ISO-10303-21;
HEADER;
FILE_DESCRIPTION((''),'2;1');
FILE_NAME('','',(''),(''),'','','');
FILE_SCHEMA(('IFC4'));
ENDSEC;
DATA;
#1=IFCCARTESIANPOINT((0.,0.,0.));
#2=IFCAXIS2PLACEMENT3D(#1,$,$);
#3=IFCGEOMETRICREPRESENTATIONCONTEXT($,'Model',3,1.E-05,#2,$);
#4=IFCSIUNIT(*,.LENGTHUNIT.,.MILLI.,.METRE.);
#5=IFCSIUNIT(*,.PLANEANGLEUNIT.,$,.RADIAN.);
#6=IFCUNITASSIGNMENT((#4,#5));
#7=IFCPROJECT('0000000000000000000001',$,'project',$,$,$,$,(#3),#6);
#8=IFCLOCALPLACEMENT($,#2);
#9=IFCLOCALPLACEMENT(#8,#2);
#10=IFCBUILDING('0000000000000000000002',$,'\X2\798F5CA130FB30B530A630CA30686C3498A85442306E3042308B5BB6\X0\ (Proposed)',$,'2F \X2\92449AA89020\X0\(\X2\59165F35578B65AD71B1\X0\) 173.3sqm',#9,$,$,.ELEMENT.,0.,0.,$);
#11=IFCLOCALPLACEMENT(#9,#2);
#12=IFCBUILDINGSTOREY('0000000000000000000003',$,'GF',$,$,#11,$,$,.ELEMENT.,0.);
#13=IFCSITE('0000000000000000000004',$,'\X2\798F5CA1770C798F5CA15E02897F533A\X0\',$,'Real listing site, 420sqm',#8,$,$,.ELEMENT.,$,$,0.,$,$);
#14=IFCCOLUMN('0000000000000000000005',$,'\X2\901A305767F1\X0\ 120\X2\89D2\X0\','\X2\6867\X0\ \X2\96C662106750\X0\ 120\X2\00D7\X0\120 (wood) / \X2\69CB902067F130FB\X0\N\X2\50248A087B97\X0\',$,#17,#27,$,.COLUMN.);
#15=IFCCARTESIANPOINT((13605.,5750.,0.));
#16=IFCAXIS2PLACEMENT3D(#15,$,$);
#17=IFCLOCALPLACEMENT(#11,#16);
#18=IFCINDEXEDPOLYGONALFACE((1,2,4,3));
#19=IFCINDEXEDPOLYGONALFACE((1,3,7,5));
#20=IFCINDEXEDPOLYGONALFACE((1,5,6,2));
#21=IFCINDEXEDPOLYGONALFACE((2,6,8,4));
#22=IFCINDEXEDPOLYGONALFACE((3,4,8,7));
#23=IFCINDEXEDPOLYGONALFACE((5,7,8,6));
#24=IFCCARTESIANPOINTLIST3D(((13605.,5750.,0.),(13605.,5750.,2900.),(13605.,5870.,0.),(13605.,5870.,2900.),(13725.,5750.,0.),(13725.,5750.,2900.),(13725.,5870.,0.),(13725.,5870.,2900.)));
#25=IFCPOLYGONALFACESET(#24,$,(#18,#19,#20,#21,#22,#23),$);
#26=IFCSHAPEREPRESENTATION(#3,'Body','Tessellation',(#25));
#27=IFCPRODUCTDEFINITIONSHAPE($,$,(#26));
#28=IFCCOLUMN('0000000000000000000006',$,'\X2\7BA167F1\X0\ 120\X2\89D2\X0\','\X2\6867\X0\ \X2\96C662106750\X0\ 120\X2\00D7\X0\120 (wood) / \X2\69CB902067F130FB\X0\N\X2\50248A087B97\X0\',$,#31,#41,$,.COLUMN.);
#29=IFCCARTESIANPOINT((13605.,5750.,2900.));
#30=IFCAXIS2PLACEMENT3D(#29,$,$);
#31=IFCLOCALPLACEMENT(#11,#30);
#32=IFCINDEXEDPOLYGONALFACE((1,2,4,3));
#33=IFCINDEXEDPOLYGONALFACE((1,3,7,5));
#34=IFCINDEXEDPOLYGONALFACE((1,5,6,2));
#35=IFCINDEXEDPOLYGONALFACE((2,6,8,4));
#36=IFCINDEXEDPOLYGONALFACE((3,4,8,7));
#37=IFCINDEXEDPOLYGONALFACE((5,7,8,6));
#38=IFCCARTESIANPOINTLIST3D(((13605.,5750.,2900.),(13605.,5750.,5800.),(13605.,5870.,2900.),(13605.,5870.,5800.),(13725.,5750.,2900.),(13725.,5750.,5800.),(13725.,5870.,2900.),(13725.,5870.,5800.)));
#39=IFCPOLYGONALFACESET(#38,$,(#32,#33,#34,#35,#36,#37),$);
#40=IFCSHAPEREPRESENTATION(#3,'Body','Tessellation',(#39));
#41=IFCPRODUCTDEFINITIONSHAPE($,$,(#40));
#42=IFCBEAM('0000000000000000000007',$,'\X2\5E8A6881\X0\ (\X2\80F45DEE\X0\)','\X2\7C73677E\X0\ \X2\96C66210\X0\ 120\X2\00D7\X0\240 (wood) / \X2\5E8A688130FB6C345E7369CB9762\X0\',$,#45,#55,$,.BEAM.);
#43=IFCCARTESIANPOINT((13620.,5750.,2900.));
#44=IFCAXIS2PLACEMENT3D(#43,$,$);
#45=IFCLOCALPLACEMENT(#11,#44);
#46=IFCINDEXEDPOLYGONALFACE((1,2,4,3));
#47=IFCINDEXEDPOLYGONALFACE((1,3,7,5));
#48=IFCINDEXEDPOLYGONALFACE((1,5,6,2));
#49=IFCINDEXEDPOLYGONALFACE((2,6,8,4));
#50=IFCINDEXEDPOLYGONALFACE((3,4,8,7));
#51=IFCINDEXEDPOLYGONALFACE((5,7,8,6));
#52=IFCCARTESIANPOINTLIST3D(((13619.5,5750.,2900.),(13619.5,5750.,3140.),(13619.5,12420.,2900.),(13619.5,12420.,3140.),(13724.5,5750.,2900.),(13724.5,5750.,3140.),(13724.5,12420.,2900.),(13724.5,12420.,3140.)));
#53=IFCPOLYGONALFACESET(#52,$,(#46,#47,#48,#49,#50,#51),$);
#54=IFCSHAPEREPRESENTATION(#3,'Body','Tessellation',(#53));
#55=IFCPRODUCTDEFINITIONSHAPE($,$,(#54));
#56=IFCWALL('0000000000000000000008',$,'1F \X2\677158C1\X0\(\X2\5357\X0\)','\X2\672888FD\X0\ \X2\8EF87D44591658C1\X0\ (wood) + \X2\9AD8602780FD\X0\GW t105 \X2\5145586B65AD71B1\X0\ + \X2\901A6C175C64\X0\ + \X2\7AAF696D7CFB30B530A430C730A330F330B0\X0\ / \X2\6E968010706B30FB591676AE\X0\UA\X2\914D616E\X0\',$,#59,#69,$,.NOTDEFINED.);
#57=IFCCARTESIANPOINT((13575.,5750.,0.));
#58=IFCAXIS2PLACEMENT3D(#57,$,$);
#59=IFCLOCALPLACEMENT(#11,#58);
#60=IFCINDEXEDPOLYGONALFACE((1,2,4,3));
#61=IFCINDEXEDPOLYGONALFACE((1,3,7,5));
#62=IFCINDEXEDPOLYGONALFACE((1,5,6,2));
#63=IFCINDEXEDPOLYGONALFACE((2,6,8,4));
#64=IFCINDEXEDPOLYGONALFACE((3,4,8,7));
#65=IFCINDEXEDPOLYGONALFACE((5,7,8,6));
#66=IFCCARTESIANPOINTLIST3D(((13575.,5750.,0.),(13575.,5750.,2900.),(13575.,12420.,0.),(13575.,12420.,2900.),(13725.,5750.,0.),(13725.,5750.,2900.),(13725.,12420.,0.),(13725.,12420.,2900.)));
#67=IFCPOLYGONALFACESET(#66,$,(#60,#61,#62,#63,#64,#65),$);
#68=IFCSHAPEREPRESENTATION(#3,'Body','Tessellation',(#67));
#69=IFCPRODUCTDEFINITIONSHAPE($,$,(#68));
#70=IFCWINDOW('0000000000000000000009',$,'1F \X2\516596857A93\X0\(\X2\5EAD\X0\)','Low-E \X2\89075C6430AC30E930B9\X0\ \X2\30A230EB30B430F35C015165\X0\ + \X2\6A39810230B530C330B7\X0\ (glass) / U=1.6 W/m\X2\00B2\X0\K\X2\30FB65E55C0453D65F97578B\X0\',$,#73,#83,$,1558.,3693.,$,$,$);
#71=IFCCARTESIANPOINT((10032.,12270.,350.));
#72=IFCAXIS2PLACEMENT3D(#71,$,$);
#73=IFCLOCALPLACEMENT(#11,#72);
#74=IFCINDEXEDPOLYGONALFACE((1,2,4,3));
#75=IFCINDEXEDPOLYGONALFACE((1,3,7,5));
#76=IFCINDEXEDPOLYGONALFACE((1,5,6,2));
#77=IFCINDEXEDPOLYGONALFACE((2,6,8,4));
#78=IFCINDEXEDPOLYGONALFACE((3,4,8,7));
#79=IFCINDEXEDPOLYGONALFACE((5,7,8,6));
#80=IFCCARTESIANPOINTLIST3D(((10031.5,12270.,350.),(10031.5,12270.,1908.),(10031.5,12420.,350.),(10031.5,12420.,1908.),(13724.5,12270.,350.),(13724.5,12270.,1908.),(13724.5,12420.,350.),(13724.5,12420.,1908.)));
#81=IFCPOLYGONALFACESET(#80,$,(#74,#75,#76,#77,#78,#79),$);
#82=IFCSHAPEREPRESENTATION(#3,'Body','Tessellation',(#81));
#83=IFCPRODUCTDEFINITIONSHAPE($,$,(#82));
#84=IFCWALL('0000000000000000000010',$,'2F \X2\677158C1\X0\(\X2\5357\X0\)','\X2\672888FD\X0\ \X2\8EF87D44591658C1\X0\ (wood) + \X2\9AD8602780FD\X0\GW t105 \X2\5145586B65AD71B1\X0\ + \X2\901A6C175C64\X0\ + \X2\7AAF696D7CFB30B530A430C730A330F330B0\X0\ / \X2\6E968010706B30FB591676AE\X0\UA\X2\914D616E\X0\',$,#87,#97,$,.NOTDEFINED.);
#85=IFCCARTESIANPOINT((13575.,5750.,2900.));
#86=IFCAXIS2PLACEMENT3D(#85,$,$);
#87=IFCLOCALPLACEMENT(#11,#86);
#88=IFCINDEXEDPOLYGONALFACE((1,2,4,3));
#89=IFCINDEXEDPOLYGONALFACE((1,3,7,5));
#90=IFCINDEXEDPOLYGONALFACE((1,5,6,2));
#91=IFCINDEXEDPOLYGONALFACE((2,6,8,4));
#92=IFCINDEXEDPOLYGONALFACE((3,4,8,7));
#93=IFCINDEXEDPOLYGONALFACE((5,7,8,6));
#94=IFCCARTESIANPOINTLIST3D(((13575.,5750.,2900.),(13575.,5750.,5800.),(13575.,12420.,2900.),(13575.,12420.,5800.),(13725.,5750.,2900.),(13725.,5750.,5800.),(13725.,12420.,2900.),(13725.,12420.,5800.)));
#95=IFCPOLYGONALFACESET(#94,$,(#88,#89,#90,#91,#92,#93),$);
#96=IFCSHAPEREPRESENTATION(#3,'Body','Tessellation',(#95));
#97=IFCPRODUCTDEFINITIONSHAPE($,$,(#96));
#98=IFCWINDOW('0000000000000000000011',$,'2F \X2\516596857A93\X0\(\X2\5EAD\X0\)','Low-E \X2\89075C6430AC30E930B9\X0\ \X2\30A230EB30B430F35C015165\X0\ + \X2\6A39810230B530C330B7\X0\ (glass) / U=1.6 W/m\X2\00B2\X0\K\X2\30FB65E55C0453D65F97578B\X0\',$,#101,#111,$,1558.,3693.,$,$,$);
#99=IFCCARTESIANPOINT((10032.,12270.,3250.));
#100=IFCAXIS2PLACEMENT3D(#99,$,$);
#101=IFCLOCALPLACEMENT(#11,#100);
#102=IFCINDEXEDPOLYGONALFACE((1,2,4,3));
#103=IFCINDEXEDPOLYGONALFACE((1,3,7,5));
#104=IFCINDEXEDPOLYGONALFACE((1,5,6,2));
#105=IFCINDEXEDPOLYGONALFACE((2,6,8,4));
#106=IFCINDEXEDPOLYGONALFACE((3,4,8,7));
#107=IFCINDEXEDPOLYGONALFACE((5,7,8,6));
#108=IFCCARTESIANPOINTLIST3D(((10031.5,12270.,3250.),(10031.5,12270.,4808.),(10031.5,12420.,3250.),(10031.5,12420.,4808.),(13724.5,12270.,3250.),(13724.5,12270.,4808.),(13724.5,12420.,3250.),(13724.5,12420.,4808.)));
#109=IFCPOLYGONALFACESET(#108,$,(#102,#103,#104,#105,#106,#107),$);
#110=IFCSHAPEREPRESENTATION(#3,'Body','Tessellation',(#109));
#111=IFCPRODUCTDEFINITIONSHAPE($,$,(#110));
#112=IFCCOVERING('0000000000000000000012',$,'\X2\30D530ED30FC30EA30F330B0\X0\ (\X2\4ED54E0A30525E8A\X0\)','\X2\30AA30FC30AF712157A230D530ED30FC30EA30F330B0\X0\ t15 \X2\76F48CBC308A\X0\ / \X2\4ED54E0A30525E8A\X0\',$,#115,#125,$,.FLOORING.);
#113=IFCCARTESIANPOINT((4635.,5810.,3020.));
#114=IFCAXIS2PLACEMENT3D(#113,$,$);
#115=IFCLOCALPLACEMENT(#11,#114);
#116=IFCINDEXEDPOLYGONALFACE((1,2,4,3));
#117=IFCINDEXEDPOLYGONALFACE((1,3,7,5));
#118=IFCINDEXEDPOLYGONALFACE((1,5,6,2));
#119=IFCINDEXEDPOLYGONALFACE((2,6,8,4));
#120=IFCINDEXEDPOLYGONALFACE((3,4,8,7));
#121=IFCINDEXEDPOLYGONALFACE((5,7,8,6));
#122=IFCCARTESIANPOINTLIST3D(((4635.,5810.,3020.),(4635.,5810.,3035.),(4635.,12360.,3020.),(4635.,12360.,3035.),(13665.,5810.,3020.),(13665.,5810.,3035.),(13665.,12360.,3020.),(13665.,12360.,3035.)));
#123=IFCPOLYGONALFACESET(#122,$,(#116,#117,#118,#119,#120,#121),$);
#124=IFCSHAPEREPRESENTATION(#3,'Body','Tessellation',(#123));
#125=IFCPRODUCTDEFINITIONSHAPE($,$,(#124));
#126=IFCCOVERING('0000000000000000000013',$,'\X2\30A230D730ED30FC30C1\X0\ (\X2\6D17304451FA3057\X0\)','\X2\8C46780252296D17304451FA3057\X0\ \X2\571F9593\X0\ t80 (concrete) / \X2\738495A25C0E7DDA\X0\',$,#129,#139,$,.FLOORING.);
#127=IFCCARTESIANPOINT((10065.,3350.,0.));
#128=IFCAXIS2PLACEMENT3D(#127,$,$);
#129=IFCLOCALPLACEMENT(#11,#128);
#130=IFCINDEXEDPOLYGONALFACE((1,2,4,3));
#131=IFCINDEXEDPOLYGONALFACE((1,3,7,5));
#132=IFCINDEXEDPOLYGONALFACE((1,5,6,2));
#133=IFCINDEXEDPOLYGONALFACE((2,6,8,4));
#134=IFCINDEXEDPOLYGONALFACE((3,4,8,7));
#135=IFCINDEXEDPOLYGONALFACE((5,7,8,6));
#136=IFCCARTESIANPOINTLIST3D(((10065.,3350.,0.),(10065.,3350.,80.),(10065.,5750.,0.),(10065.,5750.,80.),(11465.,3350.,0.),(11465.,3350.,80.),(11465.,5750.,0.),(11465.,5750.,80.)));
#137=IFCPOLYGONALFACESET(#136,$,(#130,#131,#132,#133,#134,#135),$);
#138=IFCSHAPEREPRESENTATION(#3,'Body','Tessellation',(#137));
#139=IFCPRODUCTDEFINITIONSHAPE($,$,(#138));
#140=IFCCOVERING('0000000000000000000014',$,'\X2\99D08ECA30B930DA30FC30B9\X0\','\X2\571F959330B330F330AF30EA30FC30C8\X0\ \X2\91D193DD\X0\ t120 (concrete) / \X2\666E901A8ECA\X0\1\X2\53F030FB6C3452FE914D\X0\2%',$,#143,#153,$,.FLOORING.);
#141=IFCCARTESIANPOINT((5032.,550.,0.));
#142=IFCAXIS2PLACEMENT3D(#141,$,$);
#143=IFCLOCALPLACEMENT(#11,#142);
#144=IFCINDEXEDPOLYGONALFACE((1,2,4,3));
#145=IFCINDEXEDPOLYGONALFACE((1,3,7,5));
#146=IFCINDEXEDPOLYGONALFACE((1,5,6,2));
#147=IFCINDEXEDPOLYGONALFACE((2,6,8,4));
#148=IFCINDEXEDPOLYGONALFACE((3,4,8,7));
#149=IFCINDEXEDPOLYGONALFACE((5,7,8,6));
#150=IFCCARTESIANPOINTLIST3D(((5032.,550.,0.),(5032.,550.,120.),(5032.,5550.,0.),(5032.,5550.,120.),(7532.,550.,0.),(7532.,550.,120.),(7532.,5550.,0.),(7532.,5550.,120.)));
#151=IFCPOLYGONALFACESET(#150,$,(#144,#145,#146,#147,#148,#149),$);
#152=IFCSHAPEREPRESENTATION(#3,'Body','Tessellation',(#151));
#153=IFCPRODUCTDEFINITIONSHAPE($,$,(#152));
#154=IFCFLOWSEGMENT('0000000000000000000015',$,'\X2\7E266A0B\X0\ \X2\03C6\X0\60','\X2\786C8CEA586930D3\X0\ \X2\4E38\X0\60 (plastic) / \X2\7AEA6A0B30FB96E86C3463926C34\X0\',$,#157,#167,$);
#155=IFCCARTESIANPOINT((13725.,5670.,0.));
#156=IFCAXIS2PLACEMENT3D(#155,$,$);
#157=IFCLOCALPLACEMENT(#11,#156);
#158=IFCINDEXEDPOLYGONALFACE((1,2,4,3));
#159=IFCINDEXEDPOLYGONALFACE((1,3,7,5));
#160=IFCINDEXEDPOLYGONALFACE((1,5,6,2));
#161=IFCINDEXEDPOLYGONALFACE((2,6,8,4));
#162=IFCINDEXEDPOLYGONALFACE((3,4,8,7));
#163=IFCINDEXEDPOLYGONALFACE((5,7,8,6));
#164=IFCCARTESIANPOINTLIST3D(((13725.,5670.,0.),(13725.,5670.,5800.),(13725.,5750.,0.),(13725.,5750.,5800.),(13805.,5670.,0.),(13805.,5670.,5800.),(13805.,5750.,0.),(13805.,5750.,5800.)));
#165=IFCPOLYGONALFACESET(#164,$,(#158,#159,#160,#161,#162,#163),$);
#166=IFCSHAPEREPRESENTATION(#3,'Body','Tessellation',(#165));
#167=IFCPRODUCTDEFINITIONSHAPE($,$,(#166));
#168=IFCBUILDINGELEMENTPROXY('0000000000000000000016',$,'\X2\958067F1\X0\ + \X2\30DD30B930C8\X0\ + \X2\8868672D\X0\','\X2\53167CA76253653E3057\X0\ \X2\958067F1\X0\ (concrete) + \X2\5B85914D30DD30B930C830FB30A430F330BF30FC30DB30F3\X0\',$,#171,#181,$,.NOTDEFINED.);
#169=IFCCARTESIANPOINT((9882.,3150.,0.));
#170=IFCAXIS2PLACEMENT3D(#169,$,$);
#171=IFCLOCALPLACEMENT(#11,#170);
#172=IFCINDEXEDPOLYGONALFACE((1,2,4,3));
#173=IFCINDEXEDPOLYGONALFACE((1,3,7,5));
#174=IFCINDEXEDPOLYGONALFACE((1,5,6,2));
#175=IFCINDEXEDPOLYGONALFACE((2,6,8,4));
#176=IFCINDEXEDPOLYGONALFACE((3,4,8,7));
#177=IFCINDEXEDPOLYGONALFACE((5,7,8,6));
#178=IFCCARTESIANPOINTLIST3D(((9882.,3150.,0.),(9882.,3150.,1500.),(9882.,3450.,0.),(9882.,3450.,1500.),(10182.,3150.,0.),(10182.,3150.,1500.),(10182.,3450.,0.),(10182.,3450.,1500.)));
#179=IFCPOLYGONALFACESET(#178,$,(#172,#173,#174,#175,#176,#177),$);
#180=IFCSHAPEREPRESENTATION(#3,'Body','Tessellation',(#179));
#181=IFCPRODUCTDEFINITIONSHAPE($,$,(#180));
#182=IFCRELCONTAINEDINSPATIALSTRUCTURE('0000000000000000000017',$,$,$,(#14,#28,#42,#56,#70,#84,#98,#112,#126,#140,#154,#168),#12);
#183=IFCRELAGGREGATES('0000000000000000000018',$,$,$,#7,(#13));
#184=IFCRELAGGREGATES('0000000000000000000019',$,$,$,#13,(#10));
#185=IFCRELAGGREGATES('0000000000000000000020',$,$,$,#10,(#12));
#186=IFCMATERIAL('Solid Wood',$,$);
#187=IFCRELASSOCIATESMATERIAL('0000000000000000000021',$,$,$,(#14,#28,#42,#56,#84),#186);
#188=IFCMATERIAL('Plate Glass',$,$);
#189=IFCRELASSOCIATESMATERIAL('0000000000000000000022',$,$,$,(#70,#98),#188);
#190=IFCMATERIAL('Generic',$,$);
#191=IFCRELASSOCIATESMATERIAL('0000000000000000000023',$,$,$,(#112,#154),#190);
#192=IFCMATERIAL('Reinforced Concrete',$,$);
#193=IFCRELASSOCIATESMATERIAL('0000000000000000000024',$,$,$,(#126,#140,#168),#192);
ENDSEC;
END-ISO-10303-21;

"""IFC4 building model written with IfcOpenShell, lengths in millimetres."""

from ifc_helpers import new_model, si_unit, frame, frame_2d, origin, place, context, project, spatial, rectangle, extrude, material, element, fill, save


model = new_model("IFC4")

# Units and contexts
model_context = context("Model", 3, precision=1e-05, world=origin())
ifc_project = project(units=[si_unit("LENGTHUNIT", "METRE", prefix="MILLI"), si_unit("PLANEANGLEUNIT", "RADIAN")], contexts=[model_context])

# Site, building, storey
site_placement = place(None, origin())
site = spatial("IfcSite", under=ifc_project, at=site_placement, Name="福岡県福岡市西区", ObjectType="Real listing site, 420sqm", CompositionType="ELEMENT", RefElevation=0.0)
building_placement = place(site_placement, origin())
building = spatial("IfcBuilding", under=site, at=building_placement, Name="福岡・サウナと水風呂のある家 (Proposed)", ObjectType="2F 鉄骨造(外張型断熱) 173.3sqm", CompositionType="ELEMENT", ElevationOfRefHeight=0.0, ElevationOfTerrain=0.0)
storey_placement = place(building_placement, origin())
storey = spatial("IfcBuildingStorey", under=building, at=storey_placement, Name="GF", CompositionType="ELEMENT", Elevation=0.0)

# Columns
ifc_material_1 = material(Name="Solid Wood")
column_1_placement = place(storey_placement, frame((13605.0, 5750.0, 0.0)))
element("IfcColumn", 1, at=column_1_placement, inside=storey, material=ifc_material_1, Name="通し柱 120角", Description="桧 集成材 120×120 (wood) / 構造柱・N値計算", PredefinedType="COLUMN", context=model_context, shape_type="SweptSolid", body=[
    extrude(rectangle(XDim=120.0, YDim=120.0, at=frame_2d((60.0, 60.0))), frame((13605.0, 5750.0, 0.0)), (0.0, 0.0, 1.0), 2900.0),
])
column_2_placement = place(storey_placement, frame((13605.0, 5750.0, 2900.0)))
element("IfcColumn", 2, at=column_2_placement, inside=storey, material=ifc_material_1, Name="管柱 120角", Description="桧 集成材 120×120 (wood) / 構造柱・N値計算", PredefinedType="COLUMN", context=model_context, shape_type="SweptSolid", body=[
    extrude(rectangle(XDim=120.0, YDim=120.0, at=frame_2d((60.0, 60.0))), frame((13605.0, 5750.0, 2900.0)), (0.0, 0.0, 1.0), 2900.0),
])

# Beam
beam_1_placement = place(storey_placement, frame((13620.0, 5750.0, 2900.0)))
element("IfcBeam", 3, at=beam_1_placement, inside=storey, material=ifc_material_1, Name="床梁 (胴差)", Description="米松 集成 120×240 (wood) / 床梁・水平構面", PredefinedType="BEAM", context=model_context, shape_type="SweptSolid", body=[
    extrude(rectangle(XDim=105.0, YDim=6670.0, at=frame_2d((52.0, 3335.0))), frame((13620.0, 5750.0, 2900.0)), (0.0, 0.0, 1.0), 240.0),
])

# Wall, opening, window
wall_1_placement = place(storey_placement, frame((13575.0, 5750.0, 0.0)))
wall_1 = element("IfcWall", 4, at=wall_1_placement, inside=storey, material=ifc_material_1, Name="1F 東壁(南)", Description="木製 軸組外壁 (wood) + 高性能GW t105 充填断熱 + 通気層 + 窯業系サイディング / 準耐火・外皮UA配慮", PredefinedType="NOTDEFINED", context=model_context, shape_type="SweptSolid", body=[
    extrude(rectangle(XDim=150.0, YDim=6670.0, at=frame_2d((75.0, 3335.0))), frame((13575.0, 5750.0, 0.0)), (0.0, 0.0, 1.0), 2900.0),
])
opening_1_placement = place(storey_placement, frame((10032.0, 12270.0, 350.0)))
opening_1 = element("IfcOpeningElement", 5, at=opening_1_placement, cuts=wall_1, PredefinedType="NOTDEFINED", context=model_context, shape_type="SweptSolid", body=[
    extrude(rectangle(XDim=3693.0, YDim=150.0, at=frame_2d((1846.0, 75.0))), frame((10032.0, 12270.0, 350.0)), (0.0, 0.0, 1.0), 1558.0),
])
ifc_material_2 = material(Name="Plate Glass")
window_1_placement = place(storey_placement, frame((10032.0, 12270.0, 350.0)))
window_1 = element("IfcWindow", 6, at=window_1_placement, inside=storey, material=ifc_material_2, Name="1F 入隅窓(庭)", Description="Low-E 複層ガラス アルゴン封入 + 樹脂サッシ (glass) / U=1.6 W/m²K・日射取得型", OverallHeight=1558.0, OverallWidth=3693.0, context=model_context, shape_type="SweptSolid", body=[
    extrude(rectangle(XDim=3693.0, YDim=150.0, at=frame_2d((1846.0, 75.0))), frame((10032.0, 12270.0, 350.0)), (0.0, 0.0, 1.0), 1558.0),
])
fill(opening_1, window_1)

# Wall, opening, window
wall_2_placement = place(storey_placement, frame((13575.0, 5750.0, 2900.0)))
wall_2 = element("IfcWall", 7, at=wall_2_placement, inside=storey, material=ifc_material_1, Name="2F 東壁(南)", Description="木製 軸組外壁 (wood) + 高性能GW t105 充填断熱 + 通気層 + 窯業系サイディング / 準耐火・外皮UA配慮", PredefinedType="NOTDEFINED", context=model_context, shape_type="SweptSolid", body=[
    extrude(rectangle(XDim=150.0, YDim=6670.0, at=frame_2d((75.0, 3335.0))), frame((13575.0, 5750.0, 2900.0)), (0.0, 0.0, 1.0), 2900.0),
])
opening_2_placement = place(storey_placement, frame((10032.0, 12270.0, 3250.0)))
opening_2 = element("IfcOpeningElement", 8, at=opening_2_placement, cuts=wall_2, PredefinedType="NOTDEFINED", context=model_context, shape_type="SweptSolid", body=[
    extrude(rectangle(XDim=3693.0, YDim=150.0, at=frame_2d((1846.0, 75.0))), frame((10032.0, 12270.0, 3250.0)), (0.0, 0.0, 1.0), 1558.0),
])
window_2_placement = place(storey_placement, frame((10032.0, 12270.0, 3250.0)))
window_2 = element("IfcWindow", 9, at=window_2_placement, inside=storey, material=ifc_material_2, Name="2F 入隅窓(庭)", Description="Low-E 複層ガラス アルゴン封入 + 樹脂サッシ (glass) / U=1.6 W/m²K・日射取得型", OverallHeight=1558.0, OverallWidth=3693.0, context=model_context, shape_type="SweptSolid", body=[
    extrude(rectangle(XDim=3693.0, YDim=150.0, at=frame_2d((1846.0, 75.0))), frame((10032.0, 12270.0, 3250.0)), (0.0, 0.0, 1.0), 1558.0),
])
fill(opening_2, window_2)

# Coverings
ifc_material_3 = material(Name="Generic")
covering_1_placement = place(storey_placement, frame((4635.0, 5810.0, 3020.0)))
element("IfcCovering", 10, at=covering_1_placement, inside=storey, material=ifc_material_3, Name="フローリング (仕上げ床)", Description="オーク無垢フローリング t15 直貼り / 仕上げ床", PredefinedType="FLOORING", context=model_context, shape_type="SweptSolid", body=[
    extrude(rectangle(XDim=9030.0, YDim=6550.0, at=frame_2d((4515.0, 3275.0))), frame((4635.0, 5810.0, 3020.0)), (0.0, 0.0, 1.0), 15.0),
])
ifc_material_4 = material(Name="Reinforced Concrete")
covering_2_placement = place(storey_placement, frame((10065.0, 3350.0, 0.0)))
element("IfcCovering", 11, at=covering_2_placement, inside=storey, material=ifc_material_4, Name="アプローチ (洗い出し)", Description="豆砂利洗い出し 土間 t80 (concrete) / 玄関導線", PredefinedType="FLOORING", context=model_context, shape_type="SweptSolid", body=[
    extrude(rectangle(XDim=1400.0, YDim=2400.0, at=frame_2d((700.0, 1200.0))), frame((10065.0, 3350.0, 0.0)), (0.0, 0.0, 1.0), 80.0),
])
covering_3_placement = place(storey_placement, frame((5032.0, 550.0, 0.0)))
element("IfcCovering", 12, at=covering_3_placement, inside=storey, material=ifc_material_4, Name="駐車スペース", Description="土間コンクリート 金鏝 t120 (concrete) / 普通車1台・水勾配2%", PredefinedType="FLOORING", context=model_context, shape_type="SweptSolid", body=[
    extrude(rectangle(XDim=2500.0, YDim=5000.0, at=frame_2d((1250.0, 2500.0))), frame((5032.0, 550.0, 0.0)), (0.0, 0.0, 1.0), 120.0),
])

# Flow segment
flow_segment_placement = place(storey_placement, frame((13725.0, 5670.0, 0.0)))
element("IfcFlowSegment", 13, at=flow_segment_placement, inside=storey, material=ifc_material_3, Name="縦樋 φ60", Description="硬質塩ビ 丸60 (plastic) / 竪樋・雨水排水", context=model_context, shape_type="SweptSolid", body=[
    extrude(rectangle(XDim=80.0, YDim=80.0, at=frame_2d((40.0, 40.0))), frame((13725.0, 5670.0, 0.0)), (0.0, 0.0, 1.0), 5800.0),
])

# Building element proxy
proxy_placement = place(storey_placement, frame((9882.0, 3150.0, 0.0)))
element("IfcBuildingElementProxy", 14, at=proxy_placement, inside=storey, material=ifc_material_4, Name="門柱 + ポスト + 表札", Description="化粧打放し 門柱 (concrete) + 宅配ポスト・インターホン", PredefinedType="NOTDEFINED", context=model_context, shape_type="SweptSolid", body=[
    extrude(rectangle(XDim=300.0, YDim=300.0, at=frame_2d((150.0, 150.0))), frame((9882.0, 3150.0, 0.0)), (0.0, 0.0, 1.0), 1500.0),
])

save(model, "model.ifc")
